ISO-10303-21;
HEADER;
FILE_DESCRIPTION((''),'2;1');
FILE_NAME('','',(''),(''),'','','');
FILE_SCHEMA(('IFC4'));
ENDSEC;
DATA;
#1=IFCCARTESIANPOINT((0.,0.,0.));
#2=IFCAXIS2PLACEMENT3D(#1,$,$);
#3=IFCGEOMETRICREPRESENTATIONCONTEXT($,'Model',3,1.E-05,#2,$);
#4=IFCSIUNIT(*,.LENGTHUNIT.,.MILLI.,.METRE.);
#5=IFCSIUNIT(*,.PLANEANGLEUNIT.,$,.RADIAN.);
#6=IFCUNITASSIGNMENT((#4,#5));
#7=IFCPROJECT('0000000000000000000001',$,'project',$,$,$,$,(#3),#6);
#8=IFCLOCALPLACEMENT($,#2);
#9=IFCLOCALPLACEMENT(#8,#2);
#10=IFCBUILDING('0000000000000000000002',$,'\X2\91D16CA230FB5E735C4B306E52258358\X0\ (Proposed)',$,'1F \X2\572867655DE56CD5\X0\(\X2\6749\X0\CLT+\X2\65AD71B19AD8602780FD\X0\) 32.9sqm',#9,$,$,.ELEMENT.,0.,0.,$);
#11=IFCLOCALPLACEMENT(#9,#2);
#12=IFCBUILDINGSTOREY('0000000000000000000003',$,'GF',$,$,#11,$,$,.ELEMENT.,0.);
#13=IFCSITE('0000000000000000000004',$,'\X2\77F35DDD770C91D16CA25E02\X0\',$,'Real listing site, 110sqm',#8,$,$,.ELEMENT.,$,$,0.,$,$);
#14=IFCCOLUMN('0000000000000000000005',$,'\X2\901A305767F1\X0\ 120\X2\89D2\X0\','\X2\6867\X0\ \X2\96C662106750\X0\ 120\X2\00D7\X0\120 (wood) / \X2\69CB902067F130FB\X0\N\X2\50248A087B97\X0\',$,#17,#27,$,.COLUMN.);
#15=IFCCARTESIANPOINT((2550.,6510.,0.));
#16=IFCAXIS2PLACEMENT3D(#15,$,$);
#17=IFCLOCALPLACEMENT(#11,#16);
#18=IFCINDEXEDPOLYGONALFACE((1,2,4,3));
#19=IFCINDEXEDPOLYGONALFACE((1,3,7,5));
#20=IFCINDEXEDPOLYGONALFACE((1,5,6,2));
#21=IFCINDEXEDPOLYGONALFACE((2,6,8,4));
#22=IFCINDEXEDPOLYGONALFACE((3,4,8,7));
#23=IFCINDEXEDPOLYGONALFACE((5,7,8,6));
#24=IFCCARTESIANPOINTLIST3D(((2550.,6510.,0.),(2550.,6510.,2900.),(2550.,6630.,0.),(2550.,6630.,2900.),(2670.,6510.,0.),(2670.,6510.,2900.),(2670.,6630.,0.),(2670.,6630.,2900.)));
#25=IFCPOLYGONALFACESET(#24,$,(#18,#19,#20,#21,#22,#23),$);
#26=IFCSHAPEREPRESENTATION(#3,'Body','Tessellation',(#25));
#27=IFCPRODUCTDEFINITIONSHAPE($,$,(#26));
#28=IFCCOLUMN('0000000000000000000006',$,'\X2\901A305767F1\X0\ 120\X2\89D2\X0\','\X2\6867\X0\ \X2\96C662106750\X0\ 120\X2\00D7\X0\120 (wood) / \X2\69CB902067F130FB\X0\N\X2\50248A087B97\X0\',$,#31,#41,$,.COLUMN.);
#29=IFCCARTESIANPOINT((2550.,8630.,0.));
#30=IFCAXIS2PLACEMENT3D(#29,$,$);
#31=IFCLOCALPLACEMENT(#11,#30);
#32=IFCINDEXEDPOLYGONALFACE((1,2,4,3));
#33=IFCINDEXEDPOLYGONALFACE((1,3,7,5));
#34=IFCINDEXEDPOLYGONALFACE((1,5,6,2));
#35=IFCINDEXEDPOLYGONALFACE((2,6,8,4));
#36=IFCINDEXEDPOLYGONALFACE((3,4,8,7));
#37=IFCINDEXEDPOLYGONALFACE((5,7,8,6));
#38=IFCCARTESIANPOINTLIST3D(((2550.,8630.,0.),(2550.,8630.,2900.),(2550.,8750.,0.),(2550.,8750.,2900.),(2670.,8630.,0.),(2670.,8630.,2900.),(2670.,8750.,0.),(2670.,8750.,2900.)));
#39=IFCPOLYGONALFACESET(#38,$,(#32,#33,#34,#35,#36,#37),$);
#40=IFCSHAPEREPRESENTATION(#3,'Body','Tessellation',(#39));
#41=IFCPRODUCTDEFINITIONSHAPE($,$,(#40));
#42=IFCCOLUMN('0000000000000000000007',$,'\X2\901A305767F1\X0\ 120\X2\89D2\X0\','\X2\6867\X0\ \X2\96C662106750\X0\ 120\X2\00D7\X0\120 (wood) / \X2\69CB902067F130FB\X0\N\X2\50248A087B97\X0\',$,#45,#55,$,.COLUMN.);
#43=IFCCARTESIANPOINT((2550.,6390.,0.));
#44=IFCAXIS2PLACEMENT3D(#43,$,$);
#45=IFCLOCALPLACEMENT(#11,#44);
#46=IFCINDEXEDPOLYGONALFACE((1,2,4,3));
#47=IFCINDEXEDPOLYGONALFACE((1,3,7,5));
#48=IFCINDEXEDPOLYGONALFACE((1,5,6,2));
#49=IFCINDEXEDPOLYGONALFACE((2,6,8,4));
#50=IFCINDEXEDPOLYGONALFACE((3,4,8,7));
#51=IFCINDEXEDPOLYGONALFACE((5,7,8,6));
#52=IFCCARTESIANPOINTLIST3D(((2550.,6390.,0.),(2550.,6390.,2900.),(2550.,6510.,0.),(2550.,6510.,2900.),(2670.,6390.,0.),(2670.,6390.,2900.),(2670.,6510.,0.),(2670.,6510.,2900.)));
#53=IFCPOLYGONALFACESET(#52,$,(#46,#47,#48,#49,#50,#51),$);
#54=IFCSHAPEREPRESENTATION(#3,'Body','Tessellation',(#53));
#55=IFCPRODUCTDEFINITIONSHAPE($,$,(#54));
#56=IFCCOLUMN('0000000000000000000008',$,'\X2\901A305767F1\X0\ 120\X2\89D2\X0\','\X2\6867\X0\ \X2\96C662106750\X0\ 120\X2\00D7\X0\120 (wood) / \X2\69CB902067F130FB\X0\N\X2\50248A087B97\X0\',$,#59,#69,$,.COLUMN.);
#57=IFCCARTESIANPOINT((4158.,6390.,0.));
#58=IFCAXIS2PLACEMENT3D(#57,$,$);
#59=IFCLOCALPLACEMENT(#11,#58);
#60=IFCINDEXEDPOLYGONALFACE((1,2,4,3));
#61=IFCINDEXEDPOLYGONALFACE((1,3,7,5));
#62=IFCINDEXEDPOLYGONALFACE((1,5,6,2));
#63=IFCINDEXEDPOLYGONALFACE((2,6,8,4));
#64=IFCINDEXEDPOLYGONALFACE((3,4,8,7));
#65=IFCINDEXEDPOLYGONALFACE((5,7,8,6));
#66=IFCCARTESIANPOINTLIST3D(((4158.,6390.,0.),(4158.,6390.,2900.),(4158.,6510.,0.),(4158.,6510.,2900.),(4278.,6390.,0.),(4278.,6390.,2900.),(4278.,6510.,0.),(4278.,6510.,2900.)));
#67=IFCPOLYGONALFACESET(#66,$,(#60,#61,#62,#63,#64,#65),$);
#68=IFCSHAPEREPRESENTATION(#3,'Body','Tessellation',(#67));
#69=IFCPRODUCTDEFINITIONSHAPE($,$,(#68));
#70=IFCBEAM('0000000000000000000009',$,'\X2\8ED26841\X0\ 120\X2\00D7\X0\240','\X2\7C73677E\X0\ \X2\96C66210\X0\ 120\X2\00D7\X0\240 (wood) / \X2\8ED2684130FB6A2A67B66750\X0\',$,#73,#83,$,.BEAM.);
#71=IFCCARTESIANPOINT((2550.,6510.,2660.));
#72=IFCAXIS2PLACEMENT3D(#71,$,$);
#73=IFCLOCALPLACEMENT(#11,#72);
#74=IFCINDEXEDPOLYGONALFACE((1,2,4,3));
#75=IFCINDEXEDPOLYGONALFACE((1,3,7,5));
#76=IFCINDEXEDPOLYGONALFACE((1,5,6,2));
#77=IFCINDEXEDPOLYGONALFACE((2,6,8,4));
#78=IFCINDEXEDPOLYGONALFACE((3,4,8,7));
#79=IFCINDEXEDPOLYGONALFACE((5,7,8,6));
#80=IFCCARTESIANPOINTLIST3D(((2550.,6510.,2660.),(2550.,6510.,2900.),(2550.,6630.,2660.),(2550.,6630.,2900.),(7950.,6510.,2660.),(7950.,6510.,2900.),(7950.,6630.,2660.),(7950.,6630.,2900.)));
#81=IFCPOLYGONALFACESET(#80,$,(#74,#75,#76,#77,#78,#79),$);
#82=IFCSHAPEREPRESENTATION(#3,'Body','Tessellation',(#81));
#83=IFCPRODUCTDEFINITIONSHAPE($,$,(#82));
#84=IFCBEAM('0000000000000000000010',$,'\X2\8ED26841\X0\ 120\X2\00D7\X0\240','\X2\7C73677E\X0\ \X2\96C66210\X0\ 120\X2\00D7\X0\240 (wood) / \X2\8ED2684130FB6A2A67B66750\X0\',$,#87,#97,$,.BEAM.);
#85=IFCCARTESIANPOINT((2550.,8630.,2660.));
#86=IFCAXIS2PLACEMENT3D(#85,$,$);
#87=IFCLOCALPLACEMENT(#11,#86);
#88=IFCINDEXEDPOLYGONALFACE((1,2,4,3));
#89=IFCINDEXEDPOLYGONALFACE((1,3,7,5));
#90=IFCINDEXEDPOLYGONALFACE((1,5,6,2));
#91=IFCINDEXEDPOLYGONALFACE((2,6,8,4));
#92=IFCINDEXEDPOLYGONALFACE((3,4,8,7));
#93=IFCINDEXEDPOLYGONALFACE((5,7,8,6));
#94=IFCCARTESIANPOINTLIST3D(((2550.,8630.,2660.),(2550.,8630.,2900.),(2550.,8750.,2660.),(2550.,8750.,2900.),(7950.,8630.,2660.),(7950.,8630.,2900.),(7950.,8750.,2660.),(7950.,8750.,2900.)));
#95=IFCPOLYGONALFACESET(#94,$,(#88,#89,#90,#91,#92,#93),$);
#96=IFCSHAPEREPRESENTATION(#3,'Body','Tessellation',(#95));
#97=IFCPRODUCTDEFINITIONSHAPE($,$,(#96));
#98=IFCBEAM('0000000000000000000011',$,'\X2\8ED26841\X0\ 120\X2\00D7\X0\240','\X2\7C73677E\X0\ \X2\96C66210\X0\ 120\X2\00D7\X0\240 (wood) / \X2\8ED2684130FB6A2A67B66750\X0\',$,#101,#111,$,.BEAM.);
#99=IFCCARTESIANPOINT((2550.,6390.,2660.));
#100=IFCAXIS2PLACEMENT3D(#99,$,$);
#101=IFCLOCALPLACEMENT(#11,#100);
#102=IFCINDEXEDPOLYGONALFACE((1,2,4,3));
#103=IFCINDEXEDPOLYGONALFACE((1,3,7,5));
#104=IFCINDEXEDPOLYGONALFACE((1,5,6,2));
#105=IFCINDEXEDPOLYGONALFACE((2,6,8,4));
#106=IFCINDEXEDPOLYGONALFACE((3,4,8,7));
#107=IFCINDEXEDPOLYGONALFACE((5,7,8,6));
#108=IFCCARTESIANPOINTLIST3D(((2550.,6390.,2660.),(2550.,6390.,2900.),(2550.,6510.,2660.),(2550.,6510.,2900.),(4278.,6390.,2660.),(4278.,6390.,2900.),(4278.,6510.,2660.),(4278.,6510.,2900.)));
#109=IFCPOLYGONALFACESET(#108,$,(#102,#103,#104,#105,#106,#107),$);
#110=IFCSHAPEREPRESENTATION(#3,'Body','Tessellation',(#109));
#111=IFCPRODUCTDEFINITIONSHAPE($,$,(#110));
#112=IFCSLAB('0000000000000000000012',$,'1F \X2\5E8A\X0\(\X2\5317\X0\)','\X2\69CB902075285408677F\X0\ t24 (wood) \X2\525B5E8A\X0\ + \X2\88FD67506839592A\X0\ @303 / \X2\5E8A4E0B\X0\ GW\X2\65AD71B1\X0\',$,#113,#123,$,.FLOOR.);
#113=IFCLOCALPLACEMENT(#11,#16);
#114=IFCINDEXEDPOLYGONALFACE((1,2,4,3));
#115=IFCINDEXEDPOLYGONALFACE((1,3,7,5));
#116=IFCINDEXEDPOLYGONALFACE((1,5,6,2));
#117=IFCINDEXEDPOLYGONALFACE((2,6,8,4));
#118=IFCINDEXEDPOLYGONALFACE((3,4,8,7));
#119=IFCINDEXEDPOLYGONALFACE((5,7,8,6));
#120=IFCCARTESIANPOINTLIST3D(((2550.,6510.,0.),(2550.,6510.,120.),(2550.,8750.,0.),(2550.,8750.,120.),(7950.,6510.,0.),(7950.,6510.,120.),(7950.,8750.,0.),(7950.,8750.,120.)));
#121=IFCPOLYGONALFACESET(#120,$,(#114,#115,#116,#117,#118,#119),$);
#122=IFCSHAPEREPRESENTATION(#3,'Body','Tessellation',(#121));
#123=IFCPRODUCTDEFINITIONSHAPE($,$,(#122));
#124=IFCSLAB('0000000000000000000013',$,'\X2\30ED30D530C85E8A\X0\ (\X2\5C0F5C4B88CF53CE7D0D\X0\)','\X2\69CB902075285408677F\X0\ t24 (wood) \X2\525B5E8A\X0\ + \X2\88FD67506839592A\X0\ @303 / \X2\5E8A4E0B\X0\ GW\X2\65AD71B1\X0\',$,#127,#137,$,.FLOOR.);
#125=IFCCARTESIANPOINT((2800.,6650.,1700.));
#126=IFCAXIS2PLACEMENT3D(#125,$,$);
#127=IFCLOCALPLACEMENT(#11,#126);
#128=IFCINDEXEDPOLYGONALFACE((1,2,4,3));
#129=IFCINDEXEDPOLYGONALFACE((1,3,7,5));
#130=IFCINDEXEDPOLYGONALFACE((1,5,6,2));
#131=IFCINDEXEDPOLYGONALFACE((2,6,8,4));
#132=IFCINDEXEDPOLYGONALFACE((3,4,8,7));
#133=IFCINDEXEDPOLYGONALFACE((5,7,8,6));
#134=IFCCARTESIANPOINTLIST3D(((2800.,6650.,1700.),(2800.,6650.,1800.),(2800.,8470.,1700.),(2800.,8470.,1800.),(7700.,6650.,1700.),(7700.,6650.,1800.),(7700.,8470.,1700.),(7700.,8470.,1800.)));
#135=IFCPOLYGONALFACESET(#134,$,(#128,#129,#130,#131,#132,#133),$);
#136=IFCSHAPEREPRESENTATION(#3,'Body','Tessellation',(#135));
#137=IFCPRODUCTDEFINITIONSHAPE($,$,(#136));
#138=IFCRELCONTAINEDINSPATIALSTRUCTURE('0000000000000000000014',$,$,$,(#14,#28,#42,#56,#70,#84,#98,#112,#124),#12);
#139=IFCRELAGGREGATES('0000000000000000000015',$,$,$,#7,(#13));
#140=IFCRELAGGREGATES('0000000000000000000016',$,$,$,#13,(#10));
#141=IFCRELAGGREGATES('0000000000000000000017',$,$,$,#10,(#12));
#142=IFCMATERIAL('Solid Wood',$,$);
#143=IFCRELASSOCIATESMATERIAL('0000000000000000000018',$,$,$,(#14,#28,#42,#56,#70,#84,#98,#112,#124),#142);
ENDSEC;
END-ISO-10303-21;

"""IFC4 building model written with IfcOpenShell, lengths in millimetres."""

from ifc_helpers import new_model, si_unit, frame, frame_2d, origin, place, context, project, spatial, rectangle, extrude, material, element, save


model = new_model("IFC4")

# Units and contexts
model_context = context("Model", 3, precision=1e-05, world=origin())
ifc_project = project(units=[si_unit("LENGTHUNIT", "METRE", prefix="MILLI"), si_unit("PLANEANGLEUNIT", "RADIAN")], contexts=[model_context])

# Site, building, storey
site_placement = place(None, origin())
site = spatial("IfcSite", under=ifc_project, at=site_placement, Name="石川県金沢市", ObjectType="Real listing site, 110sqm", CompositionType="ELEMENT", RefElevation=0.0)
building_placement = place(site_placement, origin())
building = spatial("IfcBuilding", under=site, at=building_placement, Name="金沢・平屋の別荘 (Proposed)", ObjectType="1F 在来工法(杉CLT+断熱高性能) 32.9sqm", CompositionType="ELEMENT", ElevationOfRefHeight=0.0, ElevationOfTerrain=0.0)
storey_placement = place(building_placement, origin())
storey = spatial("IfcBuildingStorey", under=building, at=storey_placement, Name="GF", CompositionType="ELEMENT", Elevation=0.0)

# Columns
ifc_material_1 = material(Name="Solid Wood")
column_1_placement = place(storey_placement, frame((2550.0, 6510.0, 0.0)))
element("IfcColumn", 1, at=column_1_placement, inside=storey, material=ifc_material_1, Name="通し柱 120角", Description="桧 集成材 120×120 (wood) / 構造柱・N値計算", PredefinedType="COLUMN", context=model_context, shape_type="SweptSolid", body=[
    extrude(rectangle(XDim=120.0, YDim=120.0, at=frame_2d((60.0, 60.0))), frame((2550.0, 6510.0, 0.0)), (0.0, 0.0, 1.0), 2900.0),
])
column_2_placement = place(storey_placement, frame((2550.0, 8630.0, 0.0)))
element("IfcColumn", 2, at=column_2_placement, inside=storey, material=ifc_material_1, Name="通し柱 120角", Description="桧 集成材 120×120 (wood) / 構造柱・N値計算", PredefinedType="COLUMN", context=model_context, shape_type="SweptSolid", body=[
    extrude(rectangle(XDim=120.0, YDim=120.0, at=frame_2d((60.0, 60.0))), frame((2550.0, 8630.0, 0.0)), (0.0, 0.0, 1.0), 2900.0),
])
column_3_placement = place(storey_placement, frame((2550.0, 6390.0, 0.0)))
element("IfcColumn", 3, at=column_3_placement, inside=storey, material=ifc_material_1, Name="通し柱 120角", Description="桧 集成材 120×120 (wood) / 構造柱・N値計算", PredefinedType="COLUMN", context=model_context, shape_type="SweptSolid", body=[
    extrude(rectangle(XDim=120.0, YDim=120.0, at=frame_2d((60.0, 60.0))), frame((2550.0, 6390.0, 0.0)), (0.0, 0.0, 1.0), 2900.0),
])
column_4_placement = place(storey_placement, frame((4158.0, 6390.0, 0.0)))
element("IfcColumn", 4, at=column_4_placement, inside=storey, material=ifc_material_1, Name="通し柱 120角", Description="桧 集成材 120×120 (wood) / 構造柱・N値計算", PredefinedType="COLUMN", context=model_context, shape_type="SweptSolid", body=[
    extrude(rectangle(XDim=120.0, YDim=120.0, at=frame_2d((60.0, 60.0))), frame((4158.0, 6390.0, 0.0)), (0.0, 0.0, 1.0), 2900.0),
])

# Beams
beam_1_placement = place(storey_placement, frame((2550.0, 6510.0, 2660.0)))
element("IfcBeam", 5, at=beam_1_placement, inside=storey, material=ifc_material_1, Name="軒桁 120×240", Description="米松 集成 120×240 (wood) / 軒桁・横架材", PredefinedType="BEAM", context=model_context, shape_type="SweptSolid", body=[
    extrude(rectangle(XDim=5400.0, YDim=120.0, at=frame_2d((2700.0, 60.0))), frame((2550.0, 6510.0, 2660.0)), (0.0, 0.0, 1.0), 240.0),
])
beam_2_placement = place(storey_placement, frame((2550.0, 8630.0, 2660.0)))
element("IfcBeam", 6, at=beam_2_placement, inside=storey, material=ifc_material_1, Name="軒桁 120×240", Description="米松 集成 120×240 (wood) / 軒桁・横架材", PredefinedType="BEAM", context=model_context, shape_type="SweptSolid", body=[
    extrude(rectangle(XDim=5400.0, YDim=120.0, at=frame_2d((2700.0, 60.0))), frame((2550.0, 8630.0, 2660.0)), (0.0, 0.0, 1.0), 240.0),
])
beam_3_placement = place(storey_placement, frame((2550.0, 6390.0, 2660.0)))
element("IfcBeam", 7, at=beam_3_placement, inside=storey, material=ifc_material_1, Name="軒桁 120×240", Description="米松 集成 120×240 (wood) / 軒桁・横架材", PredefinedType="BEAM", context=model_context, shape_type="SweptSolid", body=[
    extrude(rectangle(XDim=1728.0, YDim=120.0, at=frame_2d((864.0, 60.0))), frame((2550.0, 6390.0, 2660.0)), (0.0, 0.0, 1.0), 240.0),
])

# Slabs
slab_1_placement = place(storey_placement, frame((2550.0, 6510.0, 0.0)))
element("IfcSlab", 8, at=slab_1_placement, inside=storey, material=ifc_material_1, Name="1F 床(北)", Description="構造用合板 t24 (wood) 剛床 + 製材根太 @303 / 床下 GW断熱", PredefinedType="FLOOR", context=model_context, shape_type="SweptSolid", body=[
    extrude(rectangle(XDim=5400.0, YDim=2240.0, at=frame_2d((2700.0, 1120.0))), frame((2550.0, 6510.0, 0.0)), (0.0, 0.0, 1.0), 120.0),
])
slab_2_placement = place(storey_placement, frame((2800.0, 6650.0, 1700.0)))
element("IfcSlab", 9, at=slab_2_placement, inside=storey, material=ifc_material_1, Name="ロフト床 (小屋裏収納)", Description="構造用合板 t24 (wood) 剛床 + 製材根太 @303 / 床下 GW断熱", PredefinedType="FLOOR", context=model_context, shape_type="SweptSolid", body=[
    extrude(rectangle(XDim=4900.0, YDim=1820.0, at=frame_2d((2450.0, 910.0))), frame((2800.0, 6650.0, 1700.0)), (0.0, 0.0, 1.0), 100.0),
])

save(model, "model.ifc")
